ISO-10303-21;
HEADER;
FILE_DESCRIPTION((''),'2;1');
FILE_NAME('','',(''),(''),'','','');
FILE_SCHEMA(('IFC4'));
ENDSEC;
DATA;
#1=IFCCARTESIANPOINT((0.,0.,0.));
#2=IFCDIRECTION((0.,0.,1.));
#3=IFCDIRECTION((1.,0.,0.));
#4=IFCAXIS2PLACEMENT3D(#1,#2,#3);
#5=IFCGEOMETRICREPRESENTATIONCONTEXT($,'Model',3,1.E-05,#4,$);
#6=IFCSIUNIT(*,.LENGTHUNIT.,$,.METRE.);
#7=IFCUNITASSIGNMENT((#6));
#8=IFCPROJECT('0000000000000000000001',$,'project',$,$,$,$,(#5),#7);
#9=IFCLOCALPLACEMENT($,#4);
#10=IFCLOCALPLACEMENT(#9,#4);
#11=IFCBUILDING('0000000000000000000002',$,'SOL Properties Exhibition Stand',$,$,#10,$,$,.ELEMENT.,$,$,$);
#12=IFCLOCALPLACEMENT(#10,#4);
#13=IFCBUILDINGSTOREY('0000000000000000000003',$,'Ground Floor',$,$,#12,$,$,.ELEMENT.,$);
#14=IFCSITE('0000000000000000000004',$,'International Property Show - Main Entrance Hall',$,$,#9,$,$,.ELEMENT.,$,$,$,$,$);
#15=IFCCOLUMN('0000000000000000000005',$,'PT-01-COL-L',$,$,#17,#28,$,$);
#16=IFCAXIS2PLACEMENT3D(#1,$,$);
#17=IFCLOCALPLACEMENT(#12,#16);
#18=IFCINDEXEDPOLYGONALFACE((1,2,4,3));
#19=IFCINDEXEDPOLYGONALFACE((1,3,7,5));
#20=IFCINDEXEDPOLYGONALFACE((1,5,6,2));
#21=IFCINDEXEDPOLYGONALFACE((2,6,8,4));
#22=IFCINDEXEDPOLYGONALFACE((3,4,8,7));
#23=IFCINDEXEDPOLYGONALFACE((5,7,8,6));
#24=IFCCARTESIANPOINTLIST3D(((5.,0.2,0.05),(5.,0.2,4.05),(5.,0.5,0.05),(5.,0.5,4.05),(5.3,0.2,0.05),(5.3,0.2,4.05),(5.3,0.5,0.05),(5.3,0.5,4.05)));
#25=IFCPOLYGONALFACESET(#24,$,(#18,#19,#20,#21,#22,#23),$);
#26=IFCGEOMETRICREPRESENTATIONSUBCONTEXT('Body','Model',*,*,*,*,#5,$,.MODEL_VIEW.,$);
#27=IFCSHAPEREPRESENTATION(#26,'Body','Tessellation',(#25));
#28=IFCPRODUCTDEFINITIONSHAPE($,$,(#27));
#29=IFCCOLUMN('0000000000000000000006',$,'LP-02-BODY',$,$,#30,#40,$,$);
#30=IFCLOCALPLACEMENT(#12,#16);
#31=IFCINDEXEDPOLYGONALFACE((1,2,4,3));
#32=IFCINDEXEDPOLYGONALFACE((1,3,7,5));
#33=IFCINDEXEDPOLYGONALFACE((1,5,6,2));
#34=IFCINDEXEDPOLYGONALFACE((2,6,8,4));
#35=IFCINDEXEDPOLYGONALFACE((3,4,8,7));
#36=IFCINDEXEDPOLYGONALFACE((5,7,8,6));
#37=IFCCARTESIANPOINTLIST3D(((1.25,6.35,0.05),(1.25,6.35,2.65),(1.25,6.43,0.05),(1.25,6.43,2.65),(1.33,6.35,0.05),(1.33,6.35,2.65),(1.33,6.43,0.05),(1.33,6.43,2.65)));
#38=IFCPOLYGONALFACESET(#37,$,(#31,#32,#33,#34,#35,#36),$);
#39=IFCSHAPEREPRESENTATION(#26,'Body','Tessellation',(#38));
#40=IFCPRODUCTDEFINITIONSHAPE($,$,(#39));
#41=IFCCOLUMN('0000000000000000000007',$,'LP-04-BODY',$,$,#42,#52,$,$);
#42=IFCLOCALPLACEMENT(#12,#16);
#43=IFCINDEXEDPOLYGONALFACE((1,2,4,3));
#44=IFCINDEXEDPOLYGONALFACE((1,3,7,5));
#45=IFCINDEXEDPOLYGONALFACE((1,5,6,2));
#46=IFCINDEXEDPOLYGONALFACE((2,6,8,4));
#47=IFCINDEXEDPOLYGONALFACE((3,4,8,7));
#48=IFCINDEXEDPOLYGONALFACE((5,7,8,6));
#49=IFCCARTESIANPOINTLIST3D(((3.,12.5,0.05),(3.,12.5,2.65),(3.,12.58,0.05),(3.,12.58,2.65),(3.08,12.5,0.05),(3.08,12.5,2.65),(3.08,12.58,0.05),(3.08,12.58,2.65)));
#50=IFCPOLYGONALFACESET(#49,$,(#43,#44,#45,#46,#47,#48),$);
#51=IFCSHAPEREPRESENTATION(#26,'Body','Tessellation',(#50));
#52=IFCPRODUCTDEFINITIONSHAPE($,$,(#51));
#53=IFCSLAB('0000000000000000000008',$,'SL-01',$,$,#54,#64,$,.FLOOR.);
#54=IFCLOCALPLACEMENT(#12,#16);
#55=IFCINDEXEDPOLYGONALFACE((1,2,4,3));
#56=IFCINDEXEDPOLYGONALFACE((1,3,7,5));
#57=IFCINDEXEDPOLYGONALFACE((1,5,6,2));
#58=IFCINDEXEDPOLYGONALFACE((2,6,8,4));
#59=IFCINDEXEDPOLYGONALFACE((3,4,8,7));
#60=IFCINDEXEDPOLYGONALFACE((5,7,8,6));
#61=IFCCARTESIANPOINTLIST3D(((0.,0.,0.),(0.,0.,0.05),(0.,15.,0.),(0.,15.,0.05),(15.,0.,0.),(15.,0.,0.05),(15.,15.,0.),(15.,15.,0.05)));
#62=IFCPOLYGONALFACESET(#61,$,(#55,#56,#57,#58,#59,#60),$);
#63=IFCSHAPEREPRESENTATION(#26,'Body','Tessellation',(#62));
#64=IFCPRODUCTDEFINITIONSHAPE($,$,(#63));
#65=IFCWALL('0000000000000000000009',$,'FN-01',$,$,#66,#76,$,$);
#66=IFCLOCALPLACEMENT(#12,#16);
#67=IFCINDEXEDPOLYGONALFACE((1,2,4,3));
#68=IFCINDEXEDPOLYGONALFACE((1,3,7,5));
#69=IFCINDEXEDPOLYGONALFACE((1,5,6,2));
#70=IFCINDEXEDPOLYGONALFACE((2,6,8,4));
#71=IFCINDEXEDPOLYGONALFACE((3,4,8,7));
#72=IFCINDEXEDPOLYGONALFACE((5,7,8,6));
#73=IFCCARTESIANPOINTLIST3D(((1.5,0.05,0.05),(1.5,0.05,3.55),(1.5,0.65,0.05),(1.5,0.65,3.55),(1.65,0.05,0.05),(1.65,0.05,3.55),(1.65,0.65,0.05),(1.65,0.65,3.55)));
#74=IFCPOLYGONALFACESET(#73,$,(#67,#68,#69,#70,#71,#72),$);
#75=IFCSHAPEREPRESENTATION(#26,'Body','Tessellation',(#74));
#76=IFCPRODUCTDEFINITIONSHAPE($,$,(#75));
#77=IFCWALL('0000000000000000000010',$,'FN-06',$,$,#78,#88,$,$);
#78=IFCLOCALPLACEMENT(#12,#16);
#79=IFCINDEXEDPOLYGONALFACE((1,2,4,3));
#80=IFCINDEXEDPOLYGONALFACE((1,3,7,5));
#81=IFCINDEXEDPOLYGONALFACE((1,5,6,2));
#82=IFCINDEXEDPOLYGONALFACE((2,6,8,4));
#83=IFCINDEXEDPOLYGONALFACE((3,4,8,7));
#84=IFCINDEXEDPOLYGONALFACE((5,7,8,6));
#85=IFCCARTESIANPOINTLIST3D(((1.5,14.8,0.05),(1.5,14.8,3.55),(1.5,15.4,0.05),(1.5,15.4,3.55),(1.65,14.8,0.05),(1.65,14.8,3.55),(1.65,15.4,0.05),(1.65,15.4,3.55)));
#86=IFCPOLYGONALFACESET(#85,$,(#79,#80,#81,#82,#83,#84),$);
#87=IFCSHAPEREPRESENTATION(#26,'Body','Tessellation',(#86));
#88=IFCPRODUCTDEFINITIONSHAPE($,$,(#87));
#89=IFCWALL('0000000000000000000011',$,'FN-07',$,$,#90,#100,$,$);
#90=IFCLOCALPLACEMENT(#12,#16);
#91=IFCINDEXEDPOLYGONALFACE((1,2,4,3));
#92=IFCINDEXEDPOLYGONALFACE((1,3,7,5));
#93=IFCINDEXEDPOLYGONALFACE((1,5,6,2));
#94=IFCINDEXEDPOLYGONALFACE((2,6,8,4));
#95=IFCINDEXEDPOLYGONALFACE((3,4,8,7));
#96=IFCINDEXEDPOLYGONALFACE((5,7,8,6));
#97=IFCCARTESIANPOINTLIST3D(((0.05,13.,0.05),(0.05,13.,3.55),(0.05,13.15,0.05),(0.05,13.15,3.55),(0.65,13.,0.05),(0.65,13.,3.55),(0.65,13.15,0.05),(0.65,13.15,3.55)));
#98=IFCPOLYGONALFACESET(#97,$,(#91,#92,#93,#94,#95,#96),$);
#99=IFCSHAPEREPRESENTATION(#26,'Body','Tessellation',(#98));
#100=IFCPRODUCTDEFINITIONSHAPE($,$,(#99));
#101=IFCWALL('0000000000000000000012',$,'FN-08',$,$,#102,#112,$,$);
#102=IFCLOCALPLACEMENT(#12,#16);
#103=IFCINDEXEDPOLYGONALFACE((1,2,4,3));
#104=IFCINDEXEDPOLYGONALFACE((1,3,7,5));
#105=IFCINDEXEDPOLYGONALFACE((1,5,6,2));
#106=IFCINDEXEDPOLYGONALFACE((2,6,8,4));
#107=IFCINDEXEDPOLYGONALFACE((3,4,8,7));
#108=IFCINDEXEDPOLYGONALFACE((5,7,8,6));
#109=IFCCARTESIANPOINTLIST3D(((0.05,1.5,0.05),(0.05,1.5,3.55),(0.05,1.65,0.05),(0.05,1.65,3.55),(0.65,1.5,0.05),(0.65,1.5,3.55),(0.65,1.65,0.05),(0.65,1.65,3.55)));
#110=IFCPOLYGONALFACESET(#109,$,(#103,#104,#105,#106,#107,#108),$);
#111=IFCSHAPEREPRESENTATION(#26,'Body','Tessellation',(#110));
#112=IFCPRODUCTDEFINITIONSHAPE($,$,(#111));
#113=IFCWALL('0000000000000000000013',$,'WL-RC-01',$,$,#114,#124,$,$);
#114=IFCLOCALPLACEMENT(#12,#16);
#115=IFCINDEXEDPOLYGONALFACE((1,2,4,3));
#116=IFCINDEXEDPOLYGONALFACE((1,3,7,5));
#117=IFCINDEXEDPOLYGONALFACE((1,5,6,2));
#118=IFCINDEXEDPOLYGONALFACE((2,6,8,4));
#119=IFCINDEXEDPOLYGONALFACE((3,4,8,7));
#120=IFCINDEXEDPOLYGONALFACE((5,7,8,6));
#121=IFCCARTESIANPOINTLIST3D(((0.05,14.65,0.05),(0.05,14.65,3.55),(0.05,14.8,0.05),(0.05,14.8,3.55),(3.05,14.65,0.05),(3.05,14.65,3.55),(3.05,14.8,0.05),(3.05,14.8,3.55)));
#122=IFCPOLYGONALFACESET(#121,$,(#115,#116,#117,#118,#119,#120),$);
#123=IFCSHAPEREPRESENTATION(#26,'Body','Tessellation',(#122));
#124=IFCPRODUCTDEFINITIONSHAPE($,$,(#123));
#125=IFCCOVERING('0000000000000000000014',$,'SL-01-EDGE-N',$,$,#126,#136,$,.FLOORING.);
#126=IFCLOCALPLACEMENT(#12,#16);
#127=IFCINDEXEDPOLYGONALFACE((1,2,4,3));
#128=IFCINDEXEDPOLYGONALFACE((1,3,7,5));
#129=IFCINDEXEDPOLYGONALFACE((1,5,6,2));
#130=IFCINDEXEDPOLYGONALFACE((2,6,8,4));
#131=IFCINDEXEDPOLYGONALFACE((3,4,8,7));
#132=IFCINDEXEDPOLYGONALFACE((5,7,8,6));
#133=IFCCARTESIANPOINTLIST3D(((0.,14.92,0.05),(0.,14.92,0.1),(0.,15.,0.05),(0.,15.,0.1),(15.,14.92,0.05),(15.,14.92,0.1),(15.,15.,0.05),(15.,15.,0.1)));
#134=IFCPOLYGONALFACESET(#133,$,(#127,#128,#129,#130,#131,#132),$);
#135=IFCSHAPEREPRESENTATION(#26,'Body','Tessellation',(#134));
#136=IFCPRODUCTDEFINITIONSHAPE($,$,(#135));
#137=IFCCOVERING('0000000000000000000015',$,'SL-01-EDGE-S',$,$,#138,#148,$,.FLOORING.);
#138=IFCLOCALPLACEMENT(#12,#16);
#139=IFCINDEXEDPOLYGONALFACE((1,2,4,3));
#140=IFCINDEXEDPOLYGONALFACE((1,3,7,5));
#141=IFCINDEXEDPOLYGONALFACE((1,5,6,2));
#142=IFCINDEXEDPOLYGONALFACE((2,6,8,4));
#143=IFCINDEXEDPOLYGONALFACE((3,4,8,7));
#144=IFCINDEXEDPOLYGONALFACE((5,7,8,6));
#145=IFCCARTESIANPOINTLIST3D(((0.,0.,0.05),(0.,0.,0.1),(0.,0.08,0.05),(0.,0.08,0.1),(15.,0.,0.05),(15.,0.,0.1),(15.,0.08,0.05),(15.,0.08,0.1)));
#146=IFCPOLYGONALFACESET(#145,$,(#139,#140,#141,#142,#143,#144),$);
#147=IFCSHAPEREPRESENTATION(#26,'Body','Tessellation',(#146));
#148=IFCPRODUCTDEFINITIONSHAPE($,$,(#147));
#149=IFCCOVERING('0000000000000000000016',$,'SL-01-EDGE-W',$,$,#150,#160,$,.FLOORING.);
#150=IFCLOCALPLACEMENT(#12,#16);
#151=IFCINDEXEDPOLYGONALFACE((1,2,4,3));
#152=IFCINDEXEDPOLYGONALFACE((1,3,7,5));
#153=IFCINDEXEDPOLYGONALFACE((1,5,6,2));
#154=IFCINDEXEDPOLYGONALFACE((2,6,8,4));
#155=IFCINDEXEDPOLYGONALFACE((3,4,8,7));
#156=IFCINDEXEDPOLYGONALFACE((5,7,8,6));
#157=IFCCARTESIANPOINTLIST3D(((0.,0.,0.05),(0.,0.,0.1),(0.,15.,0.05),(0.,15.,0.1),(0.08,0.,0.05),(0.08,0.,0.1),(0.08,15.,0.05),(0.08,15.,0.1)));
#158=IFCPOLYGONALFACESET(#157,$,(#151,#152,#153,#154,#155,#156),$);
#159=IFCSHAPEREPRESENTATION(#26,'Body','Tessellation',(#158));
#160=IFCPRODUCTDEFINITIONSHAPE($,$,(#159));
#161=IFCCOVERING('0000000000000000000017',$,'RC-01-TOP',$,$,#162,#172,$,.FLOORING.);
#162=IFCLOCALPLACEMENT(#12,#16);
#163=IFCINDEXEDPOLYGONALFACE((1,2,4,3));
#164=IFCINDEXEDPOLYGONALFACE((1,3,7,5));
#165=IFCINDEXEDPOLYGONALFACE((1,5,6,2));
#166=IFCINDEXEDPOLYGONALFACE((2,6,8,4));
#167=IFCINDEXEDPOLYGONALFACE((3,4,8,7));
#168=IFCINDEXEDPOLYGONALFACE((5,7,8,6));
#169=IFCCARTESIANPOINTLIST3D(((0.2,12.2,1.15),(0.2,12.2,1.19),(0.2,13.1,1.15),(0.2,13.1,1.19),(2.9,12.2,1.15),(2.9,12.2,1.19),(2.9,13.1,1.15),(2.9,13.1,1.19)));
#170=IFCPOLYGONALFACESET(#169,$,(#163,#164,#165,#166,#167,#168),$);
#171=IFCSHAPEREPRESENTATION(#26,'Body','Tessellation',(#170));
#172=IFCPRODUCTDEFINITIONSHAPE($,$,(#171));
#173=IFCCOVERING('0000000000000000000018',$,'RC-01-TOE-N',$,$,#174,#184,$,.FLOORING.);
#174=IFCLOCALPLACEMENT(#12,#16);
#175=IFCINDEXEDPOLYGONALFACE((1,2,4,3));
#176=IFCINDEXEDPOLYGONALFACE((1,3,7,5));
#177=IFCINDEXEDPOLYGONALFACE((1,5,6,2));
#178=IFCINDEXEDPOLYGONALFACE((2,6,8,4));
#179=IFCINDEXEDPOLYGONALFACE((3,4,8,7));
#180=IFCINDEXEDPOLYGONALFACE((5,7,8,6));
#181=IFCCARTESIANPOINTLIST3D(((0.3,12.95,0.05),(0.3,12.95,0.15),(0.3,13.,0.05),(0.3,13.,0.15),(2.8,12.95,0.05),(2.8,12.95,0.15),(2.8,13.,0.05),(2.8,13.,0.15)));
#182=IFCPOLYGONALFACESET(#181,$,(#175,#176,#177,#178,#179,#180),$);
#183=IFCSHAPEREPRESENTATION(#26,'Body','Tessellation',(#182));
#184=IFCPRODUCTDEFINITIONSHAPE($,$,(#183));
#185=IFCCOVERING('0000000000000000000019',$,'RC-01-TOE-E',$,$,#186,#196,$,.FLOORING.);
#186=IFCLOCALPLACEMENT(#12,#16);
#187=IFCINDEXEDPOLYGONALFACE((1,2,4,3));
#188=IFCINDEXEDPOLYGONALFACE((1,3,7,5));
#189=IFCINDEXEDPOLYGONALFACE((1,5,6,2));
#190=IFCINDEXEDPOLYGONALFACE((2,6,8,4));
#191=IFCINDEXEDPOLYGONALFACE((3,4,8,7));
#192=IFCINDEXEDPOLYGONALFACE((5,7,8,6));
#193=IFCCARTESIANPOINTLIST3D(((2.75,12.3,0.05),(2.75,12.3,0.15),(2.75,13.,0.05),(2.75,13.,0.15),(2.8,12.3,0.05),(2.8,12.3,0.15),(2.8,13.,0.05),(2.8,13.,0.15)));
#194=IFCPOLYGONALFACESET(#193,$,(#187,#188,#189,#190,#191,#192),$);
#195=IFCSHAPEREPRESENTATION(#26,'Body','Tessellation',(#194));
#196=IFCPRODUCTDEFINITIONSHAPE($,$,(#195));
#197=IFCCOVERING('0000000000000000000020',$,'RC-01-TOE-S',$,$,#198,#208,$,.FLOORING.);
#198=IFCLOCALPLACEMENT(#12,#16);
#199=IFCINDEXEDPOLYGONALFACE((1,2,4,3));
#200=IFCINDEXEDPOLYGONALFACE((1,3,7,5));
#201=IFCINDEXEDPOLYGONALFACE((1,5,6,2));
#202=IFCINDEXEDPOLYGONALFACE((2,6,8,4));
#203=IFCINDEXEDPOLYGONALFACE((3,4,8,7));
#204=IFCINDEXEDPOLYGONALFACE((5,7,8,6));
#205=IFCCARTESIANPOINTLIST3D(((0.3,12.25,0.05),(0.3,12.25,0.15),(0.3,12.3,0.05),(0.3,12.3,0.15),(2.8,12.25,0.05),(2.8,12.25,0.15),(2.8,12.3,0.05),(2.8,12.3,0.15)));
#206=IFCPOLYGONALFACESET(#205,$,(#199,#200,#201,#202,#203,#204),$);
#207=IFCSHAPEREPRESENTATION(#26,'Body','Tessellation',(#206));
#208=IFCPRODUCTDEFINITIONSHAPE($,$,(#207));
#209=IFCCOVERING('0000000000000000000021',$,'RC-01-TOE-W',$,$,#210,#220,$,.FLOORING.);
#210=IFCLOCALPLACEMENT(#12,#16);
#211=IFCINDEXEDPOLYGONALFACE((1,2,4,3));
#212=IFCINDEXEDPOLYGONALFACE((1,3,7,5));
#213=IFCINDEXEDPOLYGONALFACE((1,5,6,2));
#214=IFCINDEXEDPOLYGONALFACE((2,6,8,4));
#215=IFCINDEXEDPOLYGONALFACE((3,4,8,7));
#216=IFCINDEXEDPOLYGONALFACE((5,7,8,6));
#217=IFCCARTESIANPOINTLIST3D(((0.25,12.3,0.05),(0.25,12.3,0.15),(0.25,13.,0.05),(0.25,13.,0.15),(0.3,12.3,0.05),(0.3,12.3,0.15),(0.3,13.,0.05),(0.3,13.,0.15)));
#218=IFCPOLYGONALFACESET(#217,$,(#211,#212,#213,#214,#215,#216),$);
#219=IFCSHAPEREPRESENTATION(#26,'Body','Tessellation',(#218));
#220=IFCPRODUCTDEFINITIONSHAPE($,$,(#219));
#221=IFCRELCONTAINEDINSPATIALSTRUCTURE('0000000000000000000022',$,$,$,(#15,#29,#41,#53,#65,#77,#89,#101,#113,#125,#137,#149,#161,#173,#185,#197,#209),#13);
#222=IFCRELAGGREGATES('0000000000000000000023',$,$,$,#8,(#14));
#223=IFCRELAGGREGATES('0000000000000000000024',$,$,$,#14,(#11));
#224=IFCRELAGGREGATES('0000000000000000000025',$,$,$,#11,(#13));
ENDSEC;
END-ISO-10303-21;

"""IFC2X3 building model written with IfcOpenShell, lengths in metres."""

from ifc_helpers import new_model, si_unit, frame, frame_2d, origin, origin_with_axes, place, context, subcontext, project, spatial, rectangle, extrude, element, save


model = new_model("IFC2X3")

# Units and contexts
model_context = context("Model", 3, precision=1e-05, world=origin_with_axes())
body_context = subcontext(model_context, "Body", "Model", "MODEL_VIEW")
ifc_project = project(units=[si_unit("LENGTHUNIT", "METRE")], contexts=[model_context])

# Site, building, storey
site_placement = place(None, origin_with_axes())
site = spatial("IfcSite", under=ifc_project, at=site_placement, Name="International Property Show - Main Entrance Hall", CompositionType="ELEMENT")
building_placement = place(site_placement, origin_with_axes())
building = spatial("IfcBuilding", under=site, at=building_placement, Name="SOL Properties Exhibition Stand", CompositionType="ELEMENT")
storey_placement = place(building_placement, origin_with_axes())
storey = spatial("IfcBuildingStorey", under=building, at=storey_placement, Name="Ground Floor", CompositionType="ELEMENT")

# Columns
column_placement = place(storey_placement, frame((5.0, 0.2, 0.05), z_axis=(0.0, 0.0, 1.0), x_axis=(1.0, 0.0, 0.0)))
element("IfcColumn", 1, at=column_placement, inside=storey, Name="PT-01-COL-L", context=body_context, shape_type="SweptSolid", body=[
    extrude(rectangle(XDim=0.3, YDim=0.3, at=frame_2d((0.15, 0.15))), origin(), (0.0, 0.0, 1.0), 4.0),
])
for number, where, z_axis, x_axis, name in (
    (2, (1.25, 6.35, 0.05), (0.0, 0.0, 1.0), (1.0, 0.0, 0.0), "LP-02-BODY"),
    (3, (3.0, 12.5, 0.05), (0.0, 0.0, 1.0), (1.0, 0.0, 0.0), "LP-04-BODY"),
):
    element("IfcColumn", number, at=place(storey_placement, frame(where, z_axis=z_axis, x_axis=x_axis)), inside=storey, Name=name, context=body_context, shape_type="SweptSolid", body=[
        extrude(rectangle(XDim=0.08, YDim=0.08, at=frame_2d((0.04, 0.04))), origin(), (0.0, 0.0, 1.0), 2.6),
    ])

# Slab
slab_placement = place(storey_placement, origin_with_axes())
element("IfcSlab", 4, at=slab_placement, inside=storey, Name="SL-01", PredefinedType="FLOOR", context=body_context, shape_type="SweptSolid", body=[
    extrude(rectangle(XDim=15.0, YDim=15.0, at=frame_2d((7.5, 7.5))), origin(), (0.0, 0.0, 1.0), 0.05),
])

# Walls
for number, where, z_axis, x_axis, name in (
    (5, (1.5, 0.05, 0.05), (0.0, 0.0, 1.0), (1.0, 0.0, 0.0), "FN-01"),
    (6, (1.5, 14.8, 0.05), (0.0, 0.0, 1.0), (1.0, 0.0, 0.0), "FN-06"),
):
    element("IfcWall", number, at=place(storey_placement, frame(where, z_axis=z_axis, x_axis=x_axis)), inside=storey, Name=name, context=body_context, shape_type="SweptSolid", body=[
        extrude(rectangle(XDim=0.15, YDim=0.6, at=frame_2d((0.075, 0.3))), origin(), (0.0, 0.0, 1.0), 3.5),
    ])
for number, where, z_axis, x_axis, name in (
    (7, (0.05, 13.0, 0.05), (0.0, 0.0, 1.0), (1.0, 0.0, 0.0), "FN-07"),
    (8, (0.05, 1.5, 0.05), (0.0, 0.0, 1.0), (1.0, 0.0, 0.0), "FN-08"),
):
    element("IfcWall", number, at=place(storey_placement, frame(where, z_axis=z_axis, x_axis=x_axis)), inside=storey, Name=name, context=body_context, shape_type="SweptSolid", body=[
        extrude(rectangle(XDim=0.6, YDim=0.15, at=frame_2d((0.3, 0.075))), origin(), (0.0, 0.0, 1.0), 3.5),
    ])
wall_placement = place(storey_placement, frame((0.05, 14.65, 0.05), z_axis=(0.0, 0.0, 1.0), x_axis=(1.0, 0.0, 0.0)))
element("IfcWall", 9, at=wall_placement, inside=storey, Name="WL-RC-01", context=body_context, shape_type="SweptSolid", body=[
    extrude(rectangle(XDim=3.0, YDim=0.15, at=frame_2d((1.5, 0.075))), origin(), (0.0, 0.0, 1.0), 3.5),
])

# Coverings
for number, where, z_axis, x_axis, name in (
    (10, (0.0, 14.92, 0.05), (0.0, 0.0, 1.0), (1.0, 0.0, 0.0), "SL-01-EDGE-N"),
    (11, (0.0, 0.0, 0.05), (0.0, 0.0, 1.0), (1.0, 0.0, 0.0), "SL-01-EDGE-S"),
):
    element("IfcCovering", number, at=place(storey_placement, frame(where, z_axis=z_axis, x_axis=x_axis)), inside=storey, Name=name, PredefinedType="FLOORING", context=body_context, shape_type="SweptSolid", body=[
        extrude(rectangle(XDim=15.0, YDim=0.08, at=frame_2d((7.5, 0.04))), origin(), (0.0, 0.0, 1.0), 0.05),
    ])
covering_1_placement = place(storey_placement, frame((0.0, 0.0, 0.05), z_axis=(0.0, 0.0, 1.0), x_axis=(1.0, 0.0, 0.0)))
element("IfcCovering", 12, at=covering_1_placement, inside=storey, Name="SL-01-EDGE-W", PredefinedType="FLOORING", context=body_context, shape_type="SweptSolid", body=[
    extrude(rectangle(XDim=0.08, YDim=15.0, at=frame_2d((0.04, 7.5))), origin(), (0.0, 0.0, 1.0), 0.05),
])
covering_2_placement = place(storey_placement, frame((0.2, 12.2, 1.15), z_axis=(0.0, 0.0, 1.0), x_axis=(1.0, 0.0, 0.0)))
element("IfcCovering", 13, at=covering_2_placement, inside=storey, Name="RC-01-TOP", PredefinedType="FLOORING", context=body_context, shape_type="SweptSolid", body=[
    extrude(rectangle(XDim=2.7, YDim=0.9, at=frame_2d((1.35, 0.45))), origin(), (0.0, 0.0, 1.0), 0.04),
])
covering_3_placement = place(storey_placement, frame((0.3, 12.95, 0.05), z_axis=(0.0, 0.0, 1.0), x_axis=(1.0, 0.0, 0.0)))
element("IfcCovering", 14, at=covering_3_placement, inside=storey, Name="RC-01-TOE-N", PredefinedType="FLOORING", context=body_context, shape_type="SweptSolid", body=[
    extrude(rectangle(XDim=2.5, YDim=0.05, at=frame_2d((1.25, 0.025))), origin(), (0.0, 0.0, 1.0), 0.1),
])
covering_4_placement = place(storey_placement, frame((2.75, 12.3, 0.05), z_axis=(0.0, 0.0, 1.0), x_axis=(1.0, 0.0, 0.0)))
element("IfcCovering", 15, at=covering_4_placement, inside=storey, Name="RC-01-TOE-E", PredefinedType="FLOORING", context=body_context, shape_type="SweptSolid", body=[
    extrude(rectangle(XDim=0.05, YDim=0.7, at=frame_2d((0.025, 0.35))), origin(), (0.0, 0.0, 1.0), 0.1),
])
covering_5_placement = place(storey_placement, frame((0.3, 12.25, 0.05), z_axis=(0.0, 0.0, 1.0), x_axis=(1.0, 0.0, 0.0)))
element("IfcCovering", 16, at=covering_5_placement, inside=storey, Name="RC-01-TOE-S", PredefinedType="FLOORING", context=body_context, shape_type="SweptSolid", body=[
    extrude(rectangle(XDim=2.5, YDim=0.05, at=frame_2d((1.25, 0.025))), origin(), (0.0, 0.0, 1.0), 0.1),
])
covering_6_placement = place(storey_placement, frame((0.25, 12.3, 0.05), z_axis=(0.0, 0.0, 1.0), x_axis=(1.0, 0.0, 0.0)))
element("IfcCovering", 17, at=covering_6_placement, inside=storey, Name="RC-01-TOE-W", PredefinedType="FLOORING", context=body_context, shape_type="SweptSolid", body=[
    extrude(rectangle(XDim=0.05, YDim=0.7, at=frame_2d((0.025, 0.35))), origin(), (0.0, 0.0, 1.0), 0.1),
])

save(model, "model.ifc")
